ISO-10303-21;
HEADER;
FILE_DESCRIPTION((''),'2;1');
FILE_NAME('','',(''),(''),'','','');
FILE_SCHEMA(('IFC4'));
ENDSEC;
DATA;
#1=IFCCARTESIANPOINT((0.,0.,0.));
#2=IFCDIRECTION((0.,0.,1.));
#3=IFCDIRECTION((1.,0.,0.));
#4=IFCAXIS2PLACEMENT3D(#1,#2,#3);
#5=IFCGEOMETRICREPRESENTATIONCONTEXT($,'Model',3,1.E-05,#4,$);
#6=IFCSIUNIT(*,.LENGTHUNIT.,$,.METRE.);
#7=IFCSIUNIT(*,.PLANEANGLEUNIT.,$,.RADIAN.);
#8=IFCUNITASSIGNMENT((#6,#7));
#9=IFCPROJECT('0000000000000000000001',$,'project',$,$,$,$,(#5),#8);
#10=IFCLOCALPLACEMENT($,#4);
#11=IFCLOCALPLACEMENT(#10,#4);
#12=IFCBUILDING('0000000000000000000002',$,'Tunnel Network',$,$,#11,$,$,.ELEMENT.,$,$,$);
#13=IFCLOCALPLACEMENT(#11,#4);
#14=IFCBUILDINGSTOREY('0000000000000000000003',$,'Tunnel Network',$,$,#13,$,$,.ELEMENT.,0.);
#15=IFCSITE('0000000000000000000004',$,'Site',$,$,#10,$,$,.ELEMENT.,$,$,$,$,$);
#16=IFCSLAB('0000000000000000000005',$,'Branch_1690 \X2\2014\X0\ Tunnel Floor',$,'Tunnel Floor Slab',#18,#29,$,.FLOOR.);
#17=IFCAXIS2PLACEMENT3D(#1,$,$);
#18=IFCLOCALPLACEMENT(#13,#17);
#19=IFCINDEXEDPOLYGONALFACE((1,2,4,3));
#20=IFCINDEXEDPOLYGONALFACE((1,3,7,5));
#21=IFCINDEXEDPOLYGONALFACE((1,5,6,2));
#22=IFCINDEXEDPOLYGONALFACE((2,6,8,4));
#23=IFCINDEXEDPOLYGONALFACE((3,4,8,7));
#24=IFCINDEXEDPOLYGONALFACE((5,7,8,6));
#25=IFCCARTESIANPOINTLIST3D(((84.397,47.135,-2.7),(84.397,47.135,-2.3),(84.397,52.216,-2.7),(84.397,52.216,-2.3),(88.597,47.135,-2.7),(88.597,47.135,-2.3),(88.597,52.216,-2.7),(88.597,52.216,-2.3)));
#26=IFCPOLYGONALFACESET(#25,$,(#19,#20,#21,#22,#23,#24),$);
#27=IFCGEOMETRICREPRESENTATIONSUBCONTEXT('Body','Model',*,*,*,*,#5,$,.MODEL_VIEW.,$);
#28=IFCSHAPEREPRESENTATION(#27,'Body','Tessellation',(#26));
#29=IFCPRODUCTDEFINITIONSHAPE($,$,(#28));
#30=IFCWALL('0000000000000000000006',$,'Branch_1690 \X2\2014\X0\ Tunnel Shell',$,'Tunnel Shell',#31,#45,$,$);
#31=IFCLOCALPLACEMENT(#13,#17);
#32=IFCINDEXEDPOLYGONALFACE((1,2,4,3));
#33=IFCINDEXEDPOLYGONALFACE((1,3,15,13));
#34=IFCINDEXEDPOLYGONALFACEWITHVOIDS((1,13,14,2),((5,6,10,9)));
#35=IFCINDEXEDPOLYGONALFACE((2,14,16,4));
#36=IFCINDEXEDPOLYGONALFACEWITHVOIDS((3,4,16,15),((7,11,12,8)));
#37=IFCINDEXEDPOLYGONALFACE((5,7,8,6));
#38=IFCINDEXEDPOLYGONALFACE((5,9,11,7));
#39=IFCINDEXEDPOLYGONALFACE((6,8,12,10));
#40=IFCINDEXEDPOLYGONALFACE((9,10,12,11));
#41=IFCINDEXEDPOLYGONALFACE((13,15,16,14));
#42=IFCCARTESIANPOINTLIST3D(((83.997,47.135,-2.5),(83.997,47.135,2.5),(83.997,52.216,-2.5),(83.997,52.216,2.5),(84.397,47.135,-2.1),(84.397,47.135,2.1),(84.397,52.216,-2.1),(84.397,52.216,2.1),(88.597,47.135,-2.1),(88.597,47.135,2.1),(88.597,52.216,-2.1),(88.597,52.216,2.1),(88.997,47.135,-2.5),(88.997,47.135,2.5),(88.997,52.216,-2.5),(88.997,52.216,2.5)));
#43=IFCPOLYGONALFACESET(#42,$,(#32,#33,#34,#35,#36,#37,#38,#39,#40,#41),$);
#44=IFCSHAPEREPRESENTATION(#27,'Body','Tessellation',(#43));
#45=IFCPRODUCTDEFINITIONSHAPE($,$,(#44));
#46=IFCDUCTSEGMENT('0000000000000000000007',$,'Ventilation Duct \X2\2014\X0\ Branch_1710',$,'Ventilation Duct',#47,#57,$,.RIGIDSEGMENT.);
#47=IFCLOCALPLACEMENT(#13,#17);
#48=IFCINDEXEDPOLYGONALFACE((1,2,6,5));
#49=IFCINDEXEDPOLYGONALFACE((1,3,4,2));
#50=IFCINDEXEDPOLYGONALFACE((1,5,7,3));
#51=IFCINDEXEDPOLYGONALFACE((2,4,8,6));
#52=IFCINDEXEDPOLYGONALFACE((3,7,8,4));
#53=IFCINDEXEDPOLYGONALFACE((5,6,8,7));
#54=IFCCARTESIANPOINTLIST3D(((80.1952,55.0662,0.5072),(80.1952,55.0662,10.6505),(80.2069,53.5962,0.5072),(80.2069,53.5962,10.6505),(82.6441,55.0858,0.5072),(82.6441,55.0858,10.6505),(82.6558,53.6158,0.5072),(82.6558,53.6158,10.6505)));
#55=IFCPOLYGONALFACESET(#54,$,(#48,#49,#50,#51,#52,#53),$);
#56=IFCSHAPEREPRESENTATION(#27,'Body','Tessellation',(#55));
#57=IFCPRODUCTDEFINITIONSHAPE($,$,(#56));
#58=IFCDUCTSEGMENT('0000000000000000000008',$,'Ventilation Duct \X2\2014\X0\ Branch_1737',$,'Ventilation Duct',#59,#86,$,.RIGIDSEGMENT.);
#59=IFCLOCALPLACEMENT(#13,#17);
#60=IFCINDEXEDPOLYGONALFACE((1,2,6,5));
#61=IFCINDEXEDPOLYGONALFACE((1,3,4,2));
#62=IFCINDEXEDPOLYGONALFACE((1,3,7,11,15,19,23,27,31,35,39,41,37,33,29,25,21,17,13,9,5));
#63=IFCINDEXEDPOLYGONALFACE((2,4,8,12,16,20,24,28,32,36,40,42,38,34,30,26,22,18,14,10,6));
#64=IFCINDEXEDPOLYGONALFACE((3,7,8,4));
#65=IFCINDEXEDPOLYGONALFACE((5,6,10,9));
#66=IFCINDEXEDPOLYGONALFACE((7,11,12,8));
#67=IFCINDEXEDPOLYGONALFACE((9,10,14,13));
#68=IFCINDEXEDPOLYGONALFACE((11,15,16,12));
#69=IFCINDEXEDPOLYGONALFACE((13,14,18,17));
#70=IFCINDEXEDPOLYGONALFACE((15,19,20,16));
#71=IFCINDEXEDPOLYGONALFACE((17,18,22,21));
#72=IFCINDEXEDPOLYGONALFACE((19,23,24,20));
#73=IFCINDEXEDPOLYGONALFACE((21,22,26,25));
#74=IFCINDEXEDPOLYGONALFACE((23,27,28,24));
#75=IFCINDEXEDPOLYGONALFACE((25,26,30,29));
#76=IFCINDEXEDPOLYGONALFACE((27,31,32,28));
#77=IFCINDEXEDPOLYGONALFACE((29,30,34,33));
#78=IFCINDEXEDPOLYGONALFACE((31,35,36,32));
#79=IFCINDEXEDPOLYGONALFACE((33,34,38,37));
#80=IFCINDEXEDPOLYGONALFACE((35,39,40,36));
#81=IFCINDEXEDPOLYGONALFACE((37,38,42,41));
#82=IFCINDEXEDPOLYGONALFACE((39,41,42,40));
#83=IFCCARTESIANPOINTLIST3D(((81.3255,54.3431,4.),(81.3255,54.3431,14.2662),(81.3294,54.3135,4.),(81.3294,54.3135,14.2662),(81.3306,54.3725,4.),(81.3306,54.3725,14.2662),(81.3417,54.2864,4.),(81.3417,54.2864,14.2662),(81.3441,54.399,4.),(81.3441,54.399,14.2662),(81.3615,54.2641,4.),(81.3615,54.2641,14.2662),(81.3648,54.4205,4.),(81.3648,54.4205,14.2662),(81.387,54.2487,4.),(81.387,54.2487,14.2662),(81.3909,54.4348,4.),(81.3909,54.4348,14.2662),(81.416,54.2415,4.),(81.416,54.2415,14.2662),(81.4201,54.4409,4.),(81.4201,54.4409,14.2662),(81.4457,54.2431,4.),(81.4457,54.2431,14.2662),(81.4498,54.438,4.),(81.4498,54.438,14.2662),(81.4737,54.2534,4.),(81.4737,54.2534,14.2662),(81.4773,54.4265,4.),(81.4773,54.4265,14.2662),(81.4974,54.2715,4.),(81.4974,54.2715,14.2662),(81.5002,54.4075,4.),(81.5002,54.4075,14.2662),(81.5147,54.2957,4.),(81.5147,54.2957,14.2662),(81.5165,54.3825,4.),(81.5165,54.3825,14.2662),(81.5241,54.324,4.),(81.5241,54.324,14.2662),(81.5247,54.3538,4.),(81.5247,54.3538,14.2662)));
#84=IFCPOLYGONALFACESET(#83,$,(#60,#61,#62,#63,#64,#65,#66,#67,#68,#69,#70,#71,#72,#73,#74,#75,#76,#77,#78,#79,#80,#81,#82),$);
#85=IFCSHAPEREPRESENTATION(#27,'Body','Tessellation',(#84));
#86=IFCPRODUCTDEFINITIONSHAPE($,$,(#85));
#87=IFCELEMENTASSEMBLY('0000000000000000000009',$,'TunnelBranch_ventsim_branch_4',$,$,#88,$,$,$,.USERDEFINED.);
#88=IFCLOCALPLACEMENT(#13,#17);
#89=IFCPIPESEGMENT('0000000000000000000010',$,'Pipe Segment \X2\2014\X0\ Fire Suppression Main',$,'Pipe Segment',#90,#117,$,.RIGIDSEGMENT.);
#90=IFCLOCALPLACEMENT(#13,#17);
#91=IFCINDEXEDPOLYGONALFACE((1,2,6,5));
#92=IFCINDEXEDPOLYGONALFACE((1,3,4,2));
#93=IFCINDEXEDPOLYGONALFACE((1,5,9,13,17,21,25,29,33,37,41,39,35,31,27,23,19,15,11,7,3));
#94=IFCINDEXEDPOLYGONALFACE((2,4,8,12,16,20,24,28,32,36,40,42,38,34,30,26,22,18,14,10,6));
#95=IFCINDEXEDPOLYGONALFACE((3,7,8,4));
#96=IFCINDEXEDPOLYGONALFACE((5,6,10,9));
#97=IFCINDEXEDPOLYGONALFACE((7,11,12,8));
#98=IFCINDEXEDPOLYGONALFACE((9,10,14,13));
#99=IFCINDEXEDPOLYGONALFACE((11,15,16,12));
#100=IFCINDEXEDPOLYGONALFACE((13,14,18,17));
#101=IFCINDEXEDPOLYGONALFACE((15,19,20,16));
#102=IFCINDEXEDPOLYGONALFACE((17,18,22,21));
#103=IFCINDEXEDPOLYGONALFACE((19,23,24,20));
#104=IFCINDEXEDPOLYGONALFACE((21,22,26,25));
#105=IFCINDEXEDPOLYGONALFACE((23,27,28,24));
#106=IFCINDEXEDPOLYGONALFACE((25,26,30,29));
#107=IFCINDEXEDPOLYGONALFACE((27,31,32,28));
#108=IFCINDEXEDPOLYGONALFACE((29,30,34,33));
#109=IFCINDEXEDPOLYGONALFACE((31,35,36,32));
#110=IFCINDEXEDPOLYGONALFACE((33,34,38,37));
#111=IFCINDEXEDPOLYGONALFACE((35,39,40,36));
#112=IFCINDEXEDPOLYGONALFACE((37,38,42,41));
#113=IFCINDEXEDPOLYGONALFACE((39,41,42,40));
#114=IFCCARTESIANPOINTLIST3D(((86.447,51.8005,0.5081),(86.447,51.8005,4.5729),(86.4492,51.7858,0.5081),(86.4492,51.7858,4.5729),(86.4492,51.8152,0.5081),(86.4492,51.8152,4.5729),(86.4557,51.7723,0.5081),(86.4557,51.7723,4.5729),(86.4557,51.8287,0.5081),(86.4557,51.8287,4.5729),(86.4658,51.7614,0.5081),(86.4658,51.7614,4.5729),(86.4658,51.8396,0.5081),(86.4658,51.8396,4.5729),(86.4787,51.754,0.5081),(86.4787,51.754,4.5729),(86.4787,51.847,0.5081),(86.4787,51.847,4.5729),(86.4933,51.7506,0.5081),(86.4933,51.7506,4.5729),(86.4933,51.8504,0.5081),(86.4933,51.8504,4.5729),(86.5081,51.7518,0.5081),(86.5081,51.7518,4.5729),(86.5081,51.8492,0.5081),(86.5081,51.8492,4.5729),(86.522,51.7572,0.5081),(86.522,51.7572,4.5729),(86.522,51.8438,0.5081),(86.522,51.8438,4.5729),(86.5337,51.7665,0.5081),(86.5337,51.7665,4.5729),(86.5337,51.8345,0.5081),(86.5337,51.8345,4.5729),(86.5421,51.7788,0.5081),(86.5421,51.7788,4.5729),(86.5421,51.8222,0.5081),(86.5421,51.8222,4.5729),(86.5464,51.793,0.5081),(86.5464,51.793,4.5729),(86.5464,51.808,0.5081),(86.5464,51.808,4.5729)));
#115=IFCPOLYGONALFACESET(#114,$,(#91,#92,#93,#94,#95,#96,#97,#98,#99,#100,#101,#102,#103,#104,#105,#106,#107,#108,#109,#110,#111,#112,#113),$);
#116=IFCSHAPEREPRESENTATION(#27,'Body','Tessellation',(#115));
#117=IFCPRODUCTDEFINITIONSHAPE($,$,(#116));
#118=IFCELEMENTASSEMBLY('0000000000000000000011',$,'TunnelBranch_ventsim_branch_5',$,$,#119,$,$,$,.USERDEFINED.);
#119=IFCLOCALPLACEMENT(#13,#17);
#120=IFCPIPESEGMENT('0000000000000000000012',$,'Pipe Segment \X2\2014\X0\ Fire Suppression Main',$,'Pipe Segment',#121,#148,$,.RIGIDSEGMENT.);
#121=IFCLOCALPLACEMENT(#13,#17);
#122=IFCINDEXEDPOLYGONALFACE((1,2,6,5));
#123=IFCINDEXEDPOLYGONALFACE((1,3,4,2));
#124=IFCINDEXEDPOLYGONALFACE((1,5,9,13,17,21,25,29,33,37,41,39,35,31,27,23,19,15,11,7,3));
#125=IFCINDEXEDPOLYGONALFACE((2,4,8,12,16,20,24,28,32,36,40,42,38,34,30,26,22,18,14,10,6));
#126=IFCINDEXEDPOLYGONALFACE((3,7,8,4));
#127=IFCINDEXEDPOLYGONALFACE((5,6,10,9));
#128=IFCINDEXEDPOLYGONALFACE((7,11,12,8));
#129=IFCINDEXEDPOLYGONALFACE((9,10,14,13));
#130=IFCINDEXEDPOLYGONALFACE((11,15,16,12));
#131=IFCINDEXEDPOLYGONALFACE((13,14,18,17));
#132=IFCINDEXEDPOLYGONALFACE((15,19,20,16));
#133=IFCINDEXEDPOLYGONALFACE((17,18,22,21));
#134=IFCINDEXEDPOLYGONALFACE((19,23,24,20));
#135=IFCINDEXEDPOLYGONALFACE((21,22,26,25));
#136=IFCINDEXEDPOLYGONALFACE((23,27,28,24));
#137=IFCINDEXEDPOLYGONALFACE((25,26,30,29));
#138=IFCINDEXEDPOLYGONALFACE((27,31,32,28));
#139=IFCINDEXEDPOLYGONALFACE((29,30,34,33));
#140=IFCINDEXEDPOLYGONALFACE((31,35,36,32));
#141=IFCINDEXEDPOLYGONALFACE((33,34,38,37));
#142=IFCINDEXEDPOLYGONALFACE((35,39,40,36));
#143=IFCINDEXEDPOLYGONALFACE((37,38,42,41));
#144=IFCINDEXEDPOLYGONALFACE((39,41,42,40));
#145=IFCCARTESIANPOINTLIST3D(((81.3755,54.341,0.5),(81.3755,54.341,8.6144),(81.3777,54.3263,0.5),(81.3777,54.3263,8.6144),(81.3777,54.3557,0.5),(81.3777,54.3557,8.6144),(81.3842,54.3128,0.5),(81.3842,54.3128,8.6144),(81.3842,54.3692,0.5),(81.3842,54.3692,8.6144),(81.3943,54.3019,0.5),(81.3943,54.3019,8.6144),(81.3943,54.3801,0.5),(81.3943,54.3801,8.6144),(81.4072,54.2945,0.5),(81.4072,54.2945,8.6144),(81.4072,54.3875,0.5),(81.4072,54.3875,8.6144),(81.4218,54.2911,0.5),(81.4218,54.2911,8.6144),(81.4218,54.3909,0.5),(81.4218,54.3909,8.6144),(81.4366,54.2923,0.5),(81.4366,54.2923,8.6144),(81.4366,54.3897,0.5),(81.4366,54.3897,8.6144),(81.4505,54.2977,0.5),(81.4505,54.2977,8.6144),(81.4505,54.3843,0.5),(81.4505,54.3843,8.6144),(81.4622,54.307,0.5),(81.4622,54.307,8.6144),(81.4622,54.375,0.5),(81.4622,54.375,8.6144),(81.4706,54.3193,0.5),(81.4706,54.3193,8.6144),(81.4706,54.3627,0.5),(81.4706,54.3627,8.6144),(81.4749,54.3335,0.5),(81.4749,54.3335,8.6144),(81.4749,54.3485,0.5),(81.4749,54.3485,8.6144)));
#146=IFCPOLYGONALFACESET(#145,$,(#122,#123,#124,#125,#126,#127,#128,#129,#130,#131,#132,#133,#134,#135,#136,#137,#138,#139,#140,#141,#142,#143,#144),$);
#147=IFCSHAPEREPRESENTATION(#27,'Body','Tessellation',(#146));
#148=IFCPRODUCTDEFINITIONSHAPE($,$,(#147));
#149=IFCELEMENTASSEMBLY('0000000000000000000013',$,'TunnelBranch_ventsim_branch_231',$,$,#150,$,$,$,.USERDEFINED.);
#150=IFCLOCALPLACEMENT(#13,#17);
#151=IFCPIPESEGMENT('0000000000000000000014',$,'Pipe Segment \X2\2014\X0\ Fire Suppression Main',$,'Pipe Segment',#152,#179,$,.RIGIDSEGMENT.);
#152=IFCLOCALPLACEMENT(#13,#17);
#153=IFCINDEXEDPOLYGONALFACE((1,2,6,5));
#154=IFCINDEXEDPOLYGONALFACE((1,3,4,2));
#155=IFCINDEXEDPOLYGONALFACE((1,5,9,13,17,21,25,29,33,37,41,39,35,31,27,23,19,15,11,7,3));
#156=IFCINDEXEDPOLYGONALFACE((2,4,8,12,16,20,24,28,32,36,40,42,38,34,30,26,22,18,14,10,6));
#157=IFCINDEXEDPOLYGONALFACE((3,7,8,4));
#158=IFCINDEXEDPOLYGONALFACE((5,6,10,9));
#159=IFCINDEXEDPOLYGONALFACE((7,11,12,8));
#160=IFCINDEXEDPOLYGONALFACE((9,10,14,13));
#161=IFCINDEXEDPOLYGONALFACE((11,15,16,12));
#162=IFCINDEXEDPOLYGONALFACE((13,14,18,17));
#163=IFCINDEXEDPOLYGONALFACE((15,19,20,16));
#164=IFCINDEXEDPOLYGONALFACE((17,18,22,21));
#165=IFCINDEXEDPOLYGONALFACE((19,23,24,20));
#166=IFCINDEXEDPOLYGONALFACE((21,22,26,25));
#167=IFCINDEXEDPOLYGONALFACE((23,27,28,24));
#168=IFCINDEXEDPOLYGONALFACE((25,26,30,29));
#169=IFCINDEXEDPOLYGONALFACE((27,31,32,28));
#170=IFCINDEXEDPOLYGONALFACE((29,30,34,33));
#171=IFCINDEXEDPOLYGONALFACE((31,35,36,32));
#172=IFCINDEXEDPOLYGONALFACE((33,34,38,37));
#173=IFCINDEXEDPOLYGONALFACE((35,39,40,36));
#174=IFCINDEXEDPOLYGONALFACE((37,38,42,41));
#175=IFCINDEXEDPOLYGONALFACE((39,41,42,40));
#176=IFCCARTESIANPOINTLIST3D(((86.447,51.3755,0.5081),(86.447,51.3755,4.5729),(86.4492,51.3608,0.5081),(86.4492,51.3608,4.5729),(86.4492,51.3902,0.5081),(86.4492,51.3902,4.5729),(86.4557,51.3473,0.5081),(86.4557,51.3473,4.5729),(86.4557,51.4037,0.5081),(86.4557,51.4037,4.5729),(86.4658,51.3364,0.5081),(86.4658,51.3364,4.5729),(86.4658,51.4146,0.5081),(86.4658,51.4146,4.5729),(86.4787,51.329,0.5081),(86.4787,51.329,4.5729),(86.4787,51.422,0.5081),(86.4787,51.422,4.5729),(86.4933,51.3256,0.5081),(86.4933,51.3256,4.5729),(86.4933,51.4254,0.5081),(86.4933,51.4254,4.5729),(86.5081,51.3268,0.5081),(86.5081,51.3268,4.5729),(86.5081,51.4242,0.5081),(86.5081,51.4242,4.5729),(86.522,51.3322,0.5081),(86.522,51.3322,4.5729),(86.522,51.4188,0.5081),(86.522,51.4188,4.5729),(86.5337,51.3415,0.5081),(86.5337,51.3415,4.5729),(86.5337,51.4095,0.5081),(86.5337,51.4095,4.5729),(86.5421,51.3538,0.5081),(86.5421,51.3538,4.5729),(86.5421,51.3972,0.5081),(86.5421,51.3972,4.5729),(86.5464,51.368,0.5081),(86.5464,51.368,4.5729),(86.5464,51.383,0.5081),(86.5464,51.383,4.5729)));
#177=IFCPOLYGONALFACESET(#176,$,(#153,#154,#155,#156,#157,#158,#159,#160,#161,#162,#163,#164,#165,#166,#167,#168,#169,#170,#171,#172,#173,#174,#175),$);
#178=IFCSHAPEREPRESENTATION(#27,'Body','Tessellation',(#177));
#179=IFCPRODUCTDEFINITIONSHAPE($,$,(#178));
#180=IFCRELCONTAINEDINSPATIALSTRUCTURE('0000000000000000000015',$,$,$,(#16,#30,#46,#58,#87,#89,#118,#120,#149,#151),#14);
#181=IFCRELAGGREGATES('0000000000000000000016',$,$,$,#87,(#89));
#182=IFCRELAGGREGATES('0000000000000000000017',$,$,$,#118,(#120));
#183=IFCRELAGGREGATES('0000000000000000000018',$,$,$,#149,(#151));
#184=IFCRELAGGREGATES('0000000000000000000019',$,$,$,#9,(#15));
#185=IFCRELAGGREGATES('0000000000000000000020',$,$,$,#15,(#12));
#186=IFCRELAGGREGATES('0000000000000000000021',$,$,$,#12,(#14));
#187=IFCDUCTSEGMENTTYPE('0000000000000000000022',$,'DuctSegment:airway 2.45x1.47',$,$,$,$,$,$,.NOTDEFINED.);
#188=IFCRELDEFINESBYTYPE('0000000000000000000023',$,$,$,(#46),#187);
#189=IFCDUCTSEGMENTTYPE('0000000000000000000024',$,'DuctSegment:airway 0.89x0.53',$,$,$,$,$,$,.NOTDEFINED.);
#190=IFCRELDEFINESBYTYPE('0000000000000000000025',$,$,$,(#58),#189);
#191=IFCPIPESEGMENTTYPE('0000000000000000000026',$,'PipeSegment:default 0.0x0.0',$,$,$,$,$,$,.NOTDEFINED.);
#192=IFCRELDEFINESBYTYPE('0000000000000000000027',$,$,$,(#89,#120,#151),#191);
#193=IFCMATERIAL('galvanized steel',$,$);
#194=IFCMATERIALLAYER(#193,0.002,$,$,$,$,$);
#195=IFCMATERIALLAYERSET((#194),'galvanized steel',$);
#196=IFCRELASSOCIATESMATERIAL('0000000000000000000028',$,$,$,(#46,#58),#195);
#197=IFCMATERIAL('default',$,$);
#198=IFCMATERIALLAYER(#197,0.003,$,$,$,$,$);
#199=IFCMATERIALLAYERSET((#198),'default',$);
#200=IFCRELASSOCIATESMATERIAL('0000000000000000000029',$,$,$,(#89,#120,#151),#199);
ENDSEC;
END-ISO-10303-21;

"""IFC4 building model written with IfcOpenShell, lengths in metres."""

from ifc_helpers import new_model, entity, si_unit, frame, origin_with_axes, origin_2d_with_axis, place, context, subcontext, project, spatial, rectangle, hollow_rectangle, circle, extrude, material, layer, layer_set, layer_usage, type_object, element, aggregate, save


model = new_model("IFC4")

# Units and contexts
model_context = context("Model", 3, precision=1e-05, world=origin_with_axes())
body_context = subcontext(model_context, "Body", "Model", "MODEL_VIEW")
ifc_project = project(units=[si_unit("LENGTHUNIT", "METRE"), si_unit("PLANEANGLEUNIT", "RADIAN")], contexts=[model_context])

# Site, building, storey
site_placement = place(None, origin_with_axes())
site = spatial("IfcSite", under=ifc_project, at=site_placement, Name="Site", CompositionType="ELEMENT")
building_placement = place(site_placement, origin_with_axes())
building = spatial("IfcBuilding", under=site, at=building_placement, Name="Tunnel Network", CompositionType="ELEMENT")
storey_placement = place(building_placement, origin_with_axes())
storey = spatial("IfcBuildingStorey", under=building, at=storey_placement, Name="Tunnel Network", CompositionType="ELEMENT", Elevation=0.0)

# Slab
placement = place(storey_placement, frame((86.497, 47.135, 0.0), z_axis=(0.0, 0.0, 1.0), x_axis=(0.0, 1.0, 0.0)))
element("IfcSlab", 1, at=placement, inside=storey, Name="Branch_1690 — Tunnel Floor", ObjectType="Tunnel Floor Slab", PredefinedType="FLOOR", context=body_context, shape_type="SweptSolid", body=[
    extrude(rectangle(XDim=0.4, YDim=4.2, at=origin_2d_with_axis()), frame((0.0, 0.0, -2.5), z_axis=(1.0, 0.0, 0.0), x_axis=(0.0, 0.0, 1.0)), (0.0, 0.0, 1.0), 5.081),
])

# Wall
element("IfcWall", 2, at=placement, inside=storey, Name="Branch_1690 — Tunnel Shell", ObjectType="Tunnel Shell", context=body_context, shape_type="SweptSolid", body=[
    extrude(hollow_rectangle(XDim=5.0, YDim=5.0, WallThickness=0.4, at=origin_2d_with_axis()), frame((0.0, 0.0, 0.0), z_axis=(1.0, 0.0, 0.0), x_axis=(0.0, 0.0, 1.0)), (0.0, 0.0, 1.0), 5.081),
])

# Duct segments
ifc_material_1 = material(Name="galvanized steel")
ifc_layer_1 = layer(ifc_material_1, 0.002)
ifc_layer_set_1 = layer_set([ifc_layer_1], Name="galvanized steel")
ifc_layer_usage_1 = layer_usage(ifc_layer_set_1, "AXIS2", "POSITIVE", 0.0)
duct_segment_type_1 = type_object("IfcDuctSegmentType", Name="DuctSegment:airway 2.45x1.47")
duct_segment_1_placement = place(storey_placement, frame((81.4255, 54.341, 0.5072), z_axis=(0.0, 0.0, 1.0), x_axis=(0.999968, 0.007986, 0.0)))
element("IfcDuctSegment", 3, at=duct_segment_1_placement, inside=storey, type_object=duct_segment_type_1, material=ifc_layer_usage_1, Name="Ventilation Duct — Branch_1710", ObjectType="Ventilation Duct", PredefinedType="RIGIDSEGMENT", context=body_context, shape_type="SweptSolid", body=[
    extrude(rectangle(XDim=2.449, YDim=1.47, at=origin_2d_with_axis()), origin_with_axes(), (0.0, 0.0, 1.0), 10.1433),
])
ifc_layer_usage_2 = layer_usage(ifc_layer_set_1, "AXIS2", "POSITIVE", 0.0)
duct_segment_type_2 = type_object("IfcDuctSegmentType", Name="DuctSegment:airway 0.89x0.53")
duct_segment_2_placement = place(storey_placement, frame((81.4255, 54.341, 4.0), z_axis=(0.0, 0.0, 1.0), x_axis=(-0.999783, 0.020845, 0.0)))
element("IfcDuctSegment", 4, at=duct_segment_2_placement, inside=storey, type_object=duct_segment_type_2, material=ifc_layer_usage_2, Name="Ventilation Duct — Branch_1737", ObjectType="Ventilation Duct", PredefinedType="RIGIDSEGMENT", context=body_context, shape_type="AdvancedSweptSolid", body=[
    entity("IfcSweptDiskSolid", entity("IfcPolyline", [entity("IfcCartesianPoint", [0.0, 0.0, 0.0]), entity("IfcCartesianPoint", [0.0, 0.0, 10.2662])]), 0.1),
])

# Element assemblies, pipe segments
assembly_1_placement = place(storey_placement, frame((86.497, 51.8005, 0.5081), z_axis=(0.0, 0.0, 1.0), x_axis=(-1.0, 0.0, 0.0)))
assembly_1 = element("IfcElementAssembly", 5, at=assembly_1_placement, inside=storey, Name="TunnelBranch_ventsim_branch_4", PredefinedType="USERDEFINED")
ifc_material_2 = material(Name="default")
ifc_layer_2 = layer(ifc_material_2, 0.003)
ifc_layer_set_2 = layer_set([ifc_layer_2], Name="default")
ifc_layer_usage_3 = layer_usage(ifc_layer_set_2, "AXIS2", "POSITIVE", 0.0)
pipe_segment_type = type_object("IfcPipeSegmentType", Name="PipeSegment:default 0.0x0.0")
pipe_segment_1_placement = place(storey_placement, frame((86.497, 51.8005, 0.5081), z_axis=(0.0, 0.0, 1.0), x_axis=(-1.0, 0.0, 0.0)))
pipe_segment_1 = element("IfcPipeSegment", 6, at=pipe_segment_1_placement, inside=storey, type_object=pipe_segment_type, material=ifc_layer_usage_3, Name="Pipe Segment — Fire Suppression Main", ObjectType="Pipe Segment", PredefinedType="RIGIDSEGMENT", context=body_context, shape_type="SweptSolid", body=[
    extrude(circle(Radius=0.05, at=origin_2d_with_axis()), origin_with_axes(), (0.0, 0.0, 1.0), 4.0648),
])
assembly_2_placement = place(storey_placement, frame((78.9255, 52.216, 4.0), z_axis=(0.0, 1.0, 0.0), x_axis=(-1.0, 0.0, 0.0)))
assembly_2 = element("IfcElementAssembly", 7, at=assembly_2_placement, inside=storey, Name="TunnelBranch_ventsim_branch_5", PredefinedType="USERDEFINED")
ifc_layer_usage_4 = layer_usage(ifc_layer_set_2, "AXIS2", "POSITIVE", 0.0)
pipe_segment_2_placement = place(storey_placement, frame((81.4255, 54.341, 0.5), z_axis=(0.0, 0.0, 1.0), x_axis=(-1.0, 0.0, 0.0)))
pipe_segment_2 = element("IfcPipeSegment", 8, at=pipe_segment_2_placement, inside=storey, type_object=pipe_segment_type, material=ifc_layer_usage_4, Name="Pipe Segment — Fire Suppression Main", ObjectType="Pipe Segment", PredefinedType="RIGIDSEGMENT", context=body_context, shape_type="SweptSolid", body=[
    extrude(circle(Radius=0.05, at=origin_2d_with_axis()), origin_with_axes(), (0.0, 0.0, 1.0), 8.1144),
])
assembly_3_placement = place(storey_placement, frame((86.497, 51.3755, 1.25), z_axis=(0.0, 1.0, 0.0), x_axis=(-1.0, 0.0, 0.0)))
assembly_3 = element("IfcElementAssembly", 9, at=assembly_3_placement, inside=storey, Name="TunnelBranch_ventsim_branch_231", PredefinedType="USERDEFINED")
ifc_layer_usage_5 = layer_usage(ifc_layer_set_2, "AXIS2", "POSITIVE", 0.0)
pipe_segment_3_placement = place(storey_placement, frame((86.497, 51.3755, 0.5081), z_axis=(0.0, 0.0, 1.0), x_axis=(-1.0, 0.0, 0.0)))
pipe_segment_3 = element("IfcPipeSegment", 10, at=pipe_segment_3_placement, inside=storey, type_object=pipe_segment_type, material=ifc_layer_usage_5, Name="Pipe Segment — Fire Suppression Main", ObjectType="Pipe Segment", PredefinedType="RIGIDSEGMENT", context=body_context, shape_type="SweptSolid", body=[
    extrude(circle(Radius=0.05, at=origin_2d_with_axis()), origin_with_axes(), (0.0, 0.0, 1.0), 4.0648),
])

aggregate(assembly_1, [pipe_segment_1])

aggregate(assembly_2, [pipe_segment_2])

aggregate(assembly_3, [pipe_segment_3])

save(model, "model.ifc")
